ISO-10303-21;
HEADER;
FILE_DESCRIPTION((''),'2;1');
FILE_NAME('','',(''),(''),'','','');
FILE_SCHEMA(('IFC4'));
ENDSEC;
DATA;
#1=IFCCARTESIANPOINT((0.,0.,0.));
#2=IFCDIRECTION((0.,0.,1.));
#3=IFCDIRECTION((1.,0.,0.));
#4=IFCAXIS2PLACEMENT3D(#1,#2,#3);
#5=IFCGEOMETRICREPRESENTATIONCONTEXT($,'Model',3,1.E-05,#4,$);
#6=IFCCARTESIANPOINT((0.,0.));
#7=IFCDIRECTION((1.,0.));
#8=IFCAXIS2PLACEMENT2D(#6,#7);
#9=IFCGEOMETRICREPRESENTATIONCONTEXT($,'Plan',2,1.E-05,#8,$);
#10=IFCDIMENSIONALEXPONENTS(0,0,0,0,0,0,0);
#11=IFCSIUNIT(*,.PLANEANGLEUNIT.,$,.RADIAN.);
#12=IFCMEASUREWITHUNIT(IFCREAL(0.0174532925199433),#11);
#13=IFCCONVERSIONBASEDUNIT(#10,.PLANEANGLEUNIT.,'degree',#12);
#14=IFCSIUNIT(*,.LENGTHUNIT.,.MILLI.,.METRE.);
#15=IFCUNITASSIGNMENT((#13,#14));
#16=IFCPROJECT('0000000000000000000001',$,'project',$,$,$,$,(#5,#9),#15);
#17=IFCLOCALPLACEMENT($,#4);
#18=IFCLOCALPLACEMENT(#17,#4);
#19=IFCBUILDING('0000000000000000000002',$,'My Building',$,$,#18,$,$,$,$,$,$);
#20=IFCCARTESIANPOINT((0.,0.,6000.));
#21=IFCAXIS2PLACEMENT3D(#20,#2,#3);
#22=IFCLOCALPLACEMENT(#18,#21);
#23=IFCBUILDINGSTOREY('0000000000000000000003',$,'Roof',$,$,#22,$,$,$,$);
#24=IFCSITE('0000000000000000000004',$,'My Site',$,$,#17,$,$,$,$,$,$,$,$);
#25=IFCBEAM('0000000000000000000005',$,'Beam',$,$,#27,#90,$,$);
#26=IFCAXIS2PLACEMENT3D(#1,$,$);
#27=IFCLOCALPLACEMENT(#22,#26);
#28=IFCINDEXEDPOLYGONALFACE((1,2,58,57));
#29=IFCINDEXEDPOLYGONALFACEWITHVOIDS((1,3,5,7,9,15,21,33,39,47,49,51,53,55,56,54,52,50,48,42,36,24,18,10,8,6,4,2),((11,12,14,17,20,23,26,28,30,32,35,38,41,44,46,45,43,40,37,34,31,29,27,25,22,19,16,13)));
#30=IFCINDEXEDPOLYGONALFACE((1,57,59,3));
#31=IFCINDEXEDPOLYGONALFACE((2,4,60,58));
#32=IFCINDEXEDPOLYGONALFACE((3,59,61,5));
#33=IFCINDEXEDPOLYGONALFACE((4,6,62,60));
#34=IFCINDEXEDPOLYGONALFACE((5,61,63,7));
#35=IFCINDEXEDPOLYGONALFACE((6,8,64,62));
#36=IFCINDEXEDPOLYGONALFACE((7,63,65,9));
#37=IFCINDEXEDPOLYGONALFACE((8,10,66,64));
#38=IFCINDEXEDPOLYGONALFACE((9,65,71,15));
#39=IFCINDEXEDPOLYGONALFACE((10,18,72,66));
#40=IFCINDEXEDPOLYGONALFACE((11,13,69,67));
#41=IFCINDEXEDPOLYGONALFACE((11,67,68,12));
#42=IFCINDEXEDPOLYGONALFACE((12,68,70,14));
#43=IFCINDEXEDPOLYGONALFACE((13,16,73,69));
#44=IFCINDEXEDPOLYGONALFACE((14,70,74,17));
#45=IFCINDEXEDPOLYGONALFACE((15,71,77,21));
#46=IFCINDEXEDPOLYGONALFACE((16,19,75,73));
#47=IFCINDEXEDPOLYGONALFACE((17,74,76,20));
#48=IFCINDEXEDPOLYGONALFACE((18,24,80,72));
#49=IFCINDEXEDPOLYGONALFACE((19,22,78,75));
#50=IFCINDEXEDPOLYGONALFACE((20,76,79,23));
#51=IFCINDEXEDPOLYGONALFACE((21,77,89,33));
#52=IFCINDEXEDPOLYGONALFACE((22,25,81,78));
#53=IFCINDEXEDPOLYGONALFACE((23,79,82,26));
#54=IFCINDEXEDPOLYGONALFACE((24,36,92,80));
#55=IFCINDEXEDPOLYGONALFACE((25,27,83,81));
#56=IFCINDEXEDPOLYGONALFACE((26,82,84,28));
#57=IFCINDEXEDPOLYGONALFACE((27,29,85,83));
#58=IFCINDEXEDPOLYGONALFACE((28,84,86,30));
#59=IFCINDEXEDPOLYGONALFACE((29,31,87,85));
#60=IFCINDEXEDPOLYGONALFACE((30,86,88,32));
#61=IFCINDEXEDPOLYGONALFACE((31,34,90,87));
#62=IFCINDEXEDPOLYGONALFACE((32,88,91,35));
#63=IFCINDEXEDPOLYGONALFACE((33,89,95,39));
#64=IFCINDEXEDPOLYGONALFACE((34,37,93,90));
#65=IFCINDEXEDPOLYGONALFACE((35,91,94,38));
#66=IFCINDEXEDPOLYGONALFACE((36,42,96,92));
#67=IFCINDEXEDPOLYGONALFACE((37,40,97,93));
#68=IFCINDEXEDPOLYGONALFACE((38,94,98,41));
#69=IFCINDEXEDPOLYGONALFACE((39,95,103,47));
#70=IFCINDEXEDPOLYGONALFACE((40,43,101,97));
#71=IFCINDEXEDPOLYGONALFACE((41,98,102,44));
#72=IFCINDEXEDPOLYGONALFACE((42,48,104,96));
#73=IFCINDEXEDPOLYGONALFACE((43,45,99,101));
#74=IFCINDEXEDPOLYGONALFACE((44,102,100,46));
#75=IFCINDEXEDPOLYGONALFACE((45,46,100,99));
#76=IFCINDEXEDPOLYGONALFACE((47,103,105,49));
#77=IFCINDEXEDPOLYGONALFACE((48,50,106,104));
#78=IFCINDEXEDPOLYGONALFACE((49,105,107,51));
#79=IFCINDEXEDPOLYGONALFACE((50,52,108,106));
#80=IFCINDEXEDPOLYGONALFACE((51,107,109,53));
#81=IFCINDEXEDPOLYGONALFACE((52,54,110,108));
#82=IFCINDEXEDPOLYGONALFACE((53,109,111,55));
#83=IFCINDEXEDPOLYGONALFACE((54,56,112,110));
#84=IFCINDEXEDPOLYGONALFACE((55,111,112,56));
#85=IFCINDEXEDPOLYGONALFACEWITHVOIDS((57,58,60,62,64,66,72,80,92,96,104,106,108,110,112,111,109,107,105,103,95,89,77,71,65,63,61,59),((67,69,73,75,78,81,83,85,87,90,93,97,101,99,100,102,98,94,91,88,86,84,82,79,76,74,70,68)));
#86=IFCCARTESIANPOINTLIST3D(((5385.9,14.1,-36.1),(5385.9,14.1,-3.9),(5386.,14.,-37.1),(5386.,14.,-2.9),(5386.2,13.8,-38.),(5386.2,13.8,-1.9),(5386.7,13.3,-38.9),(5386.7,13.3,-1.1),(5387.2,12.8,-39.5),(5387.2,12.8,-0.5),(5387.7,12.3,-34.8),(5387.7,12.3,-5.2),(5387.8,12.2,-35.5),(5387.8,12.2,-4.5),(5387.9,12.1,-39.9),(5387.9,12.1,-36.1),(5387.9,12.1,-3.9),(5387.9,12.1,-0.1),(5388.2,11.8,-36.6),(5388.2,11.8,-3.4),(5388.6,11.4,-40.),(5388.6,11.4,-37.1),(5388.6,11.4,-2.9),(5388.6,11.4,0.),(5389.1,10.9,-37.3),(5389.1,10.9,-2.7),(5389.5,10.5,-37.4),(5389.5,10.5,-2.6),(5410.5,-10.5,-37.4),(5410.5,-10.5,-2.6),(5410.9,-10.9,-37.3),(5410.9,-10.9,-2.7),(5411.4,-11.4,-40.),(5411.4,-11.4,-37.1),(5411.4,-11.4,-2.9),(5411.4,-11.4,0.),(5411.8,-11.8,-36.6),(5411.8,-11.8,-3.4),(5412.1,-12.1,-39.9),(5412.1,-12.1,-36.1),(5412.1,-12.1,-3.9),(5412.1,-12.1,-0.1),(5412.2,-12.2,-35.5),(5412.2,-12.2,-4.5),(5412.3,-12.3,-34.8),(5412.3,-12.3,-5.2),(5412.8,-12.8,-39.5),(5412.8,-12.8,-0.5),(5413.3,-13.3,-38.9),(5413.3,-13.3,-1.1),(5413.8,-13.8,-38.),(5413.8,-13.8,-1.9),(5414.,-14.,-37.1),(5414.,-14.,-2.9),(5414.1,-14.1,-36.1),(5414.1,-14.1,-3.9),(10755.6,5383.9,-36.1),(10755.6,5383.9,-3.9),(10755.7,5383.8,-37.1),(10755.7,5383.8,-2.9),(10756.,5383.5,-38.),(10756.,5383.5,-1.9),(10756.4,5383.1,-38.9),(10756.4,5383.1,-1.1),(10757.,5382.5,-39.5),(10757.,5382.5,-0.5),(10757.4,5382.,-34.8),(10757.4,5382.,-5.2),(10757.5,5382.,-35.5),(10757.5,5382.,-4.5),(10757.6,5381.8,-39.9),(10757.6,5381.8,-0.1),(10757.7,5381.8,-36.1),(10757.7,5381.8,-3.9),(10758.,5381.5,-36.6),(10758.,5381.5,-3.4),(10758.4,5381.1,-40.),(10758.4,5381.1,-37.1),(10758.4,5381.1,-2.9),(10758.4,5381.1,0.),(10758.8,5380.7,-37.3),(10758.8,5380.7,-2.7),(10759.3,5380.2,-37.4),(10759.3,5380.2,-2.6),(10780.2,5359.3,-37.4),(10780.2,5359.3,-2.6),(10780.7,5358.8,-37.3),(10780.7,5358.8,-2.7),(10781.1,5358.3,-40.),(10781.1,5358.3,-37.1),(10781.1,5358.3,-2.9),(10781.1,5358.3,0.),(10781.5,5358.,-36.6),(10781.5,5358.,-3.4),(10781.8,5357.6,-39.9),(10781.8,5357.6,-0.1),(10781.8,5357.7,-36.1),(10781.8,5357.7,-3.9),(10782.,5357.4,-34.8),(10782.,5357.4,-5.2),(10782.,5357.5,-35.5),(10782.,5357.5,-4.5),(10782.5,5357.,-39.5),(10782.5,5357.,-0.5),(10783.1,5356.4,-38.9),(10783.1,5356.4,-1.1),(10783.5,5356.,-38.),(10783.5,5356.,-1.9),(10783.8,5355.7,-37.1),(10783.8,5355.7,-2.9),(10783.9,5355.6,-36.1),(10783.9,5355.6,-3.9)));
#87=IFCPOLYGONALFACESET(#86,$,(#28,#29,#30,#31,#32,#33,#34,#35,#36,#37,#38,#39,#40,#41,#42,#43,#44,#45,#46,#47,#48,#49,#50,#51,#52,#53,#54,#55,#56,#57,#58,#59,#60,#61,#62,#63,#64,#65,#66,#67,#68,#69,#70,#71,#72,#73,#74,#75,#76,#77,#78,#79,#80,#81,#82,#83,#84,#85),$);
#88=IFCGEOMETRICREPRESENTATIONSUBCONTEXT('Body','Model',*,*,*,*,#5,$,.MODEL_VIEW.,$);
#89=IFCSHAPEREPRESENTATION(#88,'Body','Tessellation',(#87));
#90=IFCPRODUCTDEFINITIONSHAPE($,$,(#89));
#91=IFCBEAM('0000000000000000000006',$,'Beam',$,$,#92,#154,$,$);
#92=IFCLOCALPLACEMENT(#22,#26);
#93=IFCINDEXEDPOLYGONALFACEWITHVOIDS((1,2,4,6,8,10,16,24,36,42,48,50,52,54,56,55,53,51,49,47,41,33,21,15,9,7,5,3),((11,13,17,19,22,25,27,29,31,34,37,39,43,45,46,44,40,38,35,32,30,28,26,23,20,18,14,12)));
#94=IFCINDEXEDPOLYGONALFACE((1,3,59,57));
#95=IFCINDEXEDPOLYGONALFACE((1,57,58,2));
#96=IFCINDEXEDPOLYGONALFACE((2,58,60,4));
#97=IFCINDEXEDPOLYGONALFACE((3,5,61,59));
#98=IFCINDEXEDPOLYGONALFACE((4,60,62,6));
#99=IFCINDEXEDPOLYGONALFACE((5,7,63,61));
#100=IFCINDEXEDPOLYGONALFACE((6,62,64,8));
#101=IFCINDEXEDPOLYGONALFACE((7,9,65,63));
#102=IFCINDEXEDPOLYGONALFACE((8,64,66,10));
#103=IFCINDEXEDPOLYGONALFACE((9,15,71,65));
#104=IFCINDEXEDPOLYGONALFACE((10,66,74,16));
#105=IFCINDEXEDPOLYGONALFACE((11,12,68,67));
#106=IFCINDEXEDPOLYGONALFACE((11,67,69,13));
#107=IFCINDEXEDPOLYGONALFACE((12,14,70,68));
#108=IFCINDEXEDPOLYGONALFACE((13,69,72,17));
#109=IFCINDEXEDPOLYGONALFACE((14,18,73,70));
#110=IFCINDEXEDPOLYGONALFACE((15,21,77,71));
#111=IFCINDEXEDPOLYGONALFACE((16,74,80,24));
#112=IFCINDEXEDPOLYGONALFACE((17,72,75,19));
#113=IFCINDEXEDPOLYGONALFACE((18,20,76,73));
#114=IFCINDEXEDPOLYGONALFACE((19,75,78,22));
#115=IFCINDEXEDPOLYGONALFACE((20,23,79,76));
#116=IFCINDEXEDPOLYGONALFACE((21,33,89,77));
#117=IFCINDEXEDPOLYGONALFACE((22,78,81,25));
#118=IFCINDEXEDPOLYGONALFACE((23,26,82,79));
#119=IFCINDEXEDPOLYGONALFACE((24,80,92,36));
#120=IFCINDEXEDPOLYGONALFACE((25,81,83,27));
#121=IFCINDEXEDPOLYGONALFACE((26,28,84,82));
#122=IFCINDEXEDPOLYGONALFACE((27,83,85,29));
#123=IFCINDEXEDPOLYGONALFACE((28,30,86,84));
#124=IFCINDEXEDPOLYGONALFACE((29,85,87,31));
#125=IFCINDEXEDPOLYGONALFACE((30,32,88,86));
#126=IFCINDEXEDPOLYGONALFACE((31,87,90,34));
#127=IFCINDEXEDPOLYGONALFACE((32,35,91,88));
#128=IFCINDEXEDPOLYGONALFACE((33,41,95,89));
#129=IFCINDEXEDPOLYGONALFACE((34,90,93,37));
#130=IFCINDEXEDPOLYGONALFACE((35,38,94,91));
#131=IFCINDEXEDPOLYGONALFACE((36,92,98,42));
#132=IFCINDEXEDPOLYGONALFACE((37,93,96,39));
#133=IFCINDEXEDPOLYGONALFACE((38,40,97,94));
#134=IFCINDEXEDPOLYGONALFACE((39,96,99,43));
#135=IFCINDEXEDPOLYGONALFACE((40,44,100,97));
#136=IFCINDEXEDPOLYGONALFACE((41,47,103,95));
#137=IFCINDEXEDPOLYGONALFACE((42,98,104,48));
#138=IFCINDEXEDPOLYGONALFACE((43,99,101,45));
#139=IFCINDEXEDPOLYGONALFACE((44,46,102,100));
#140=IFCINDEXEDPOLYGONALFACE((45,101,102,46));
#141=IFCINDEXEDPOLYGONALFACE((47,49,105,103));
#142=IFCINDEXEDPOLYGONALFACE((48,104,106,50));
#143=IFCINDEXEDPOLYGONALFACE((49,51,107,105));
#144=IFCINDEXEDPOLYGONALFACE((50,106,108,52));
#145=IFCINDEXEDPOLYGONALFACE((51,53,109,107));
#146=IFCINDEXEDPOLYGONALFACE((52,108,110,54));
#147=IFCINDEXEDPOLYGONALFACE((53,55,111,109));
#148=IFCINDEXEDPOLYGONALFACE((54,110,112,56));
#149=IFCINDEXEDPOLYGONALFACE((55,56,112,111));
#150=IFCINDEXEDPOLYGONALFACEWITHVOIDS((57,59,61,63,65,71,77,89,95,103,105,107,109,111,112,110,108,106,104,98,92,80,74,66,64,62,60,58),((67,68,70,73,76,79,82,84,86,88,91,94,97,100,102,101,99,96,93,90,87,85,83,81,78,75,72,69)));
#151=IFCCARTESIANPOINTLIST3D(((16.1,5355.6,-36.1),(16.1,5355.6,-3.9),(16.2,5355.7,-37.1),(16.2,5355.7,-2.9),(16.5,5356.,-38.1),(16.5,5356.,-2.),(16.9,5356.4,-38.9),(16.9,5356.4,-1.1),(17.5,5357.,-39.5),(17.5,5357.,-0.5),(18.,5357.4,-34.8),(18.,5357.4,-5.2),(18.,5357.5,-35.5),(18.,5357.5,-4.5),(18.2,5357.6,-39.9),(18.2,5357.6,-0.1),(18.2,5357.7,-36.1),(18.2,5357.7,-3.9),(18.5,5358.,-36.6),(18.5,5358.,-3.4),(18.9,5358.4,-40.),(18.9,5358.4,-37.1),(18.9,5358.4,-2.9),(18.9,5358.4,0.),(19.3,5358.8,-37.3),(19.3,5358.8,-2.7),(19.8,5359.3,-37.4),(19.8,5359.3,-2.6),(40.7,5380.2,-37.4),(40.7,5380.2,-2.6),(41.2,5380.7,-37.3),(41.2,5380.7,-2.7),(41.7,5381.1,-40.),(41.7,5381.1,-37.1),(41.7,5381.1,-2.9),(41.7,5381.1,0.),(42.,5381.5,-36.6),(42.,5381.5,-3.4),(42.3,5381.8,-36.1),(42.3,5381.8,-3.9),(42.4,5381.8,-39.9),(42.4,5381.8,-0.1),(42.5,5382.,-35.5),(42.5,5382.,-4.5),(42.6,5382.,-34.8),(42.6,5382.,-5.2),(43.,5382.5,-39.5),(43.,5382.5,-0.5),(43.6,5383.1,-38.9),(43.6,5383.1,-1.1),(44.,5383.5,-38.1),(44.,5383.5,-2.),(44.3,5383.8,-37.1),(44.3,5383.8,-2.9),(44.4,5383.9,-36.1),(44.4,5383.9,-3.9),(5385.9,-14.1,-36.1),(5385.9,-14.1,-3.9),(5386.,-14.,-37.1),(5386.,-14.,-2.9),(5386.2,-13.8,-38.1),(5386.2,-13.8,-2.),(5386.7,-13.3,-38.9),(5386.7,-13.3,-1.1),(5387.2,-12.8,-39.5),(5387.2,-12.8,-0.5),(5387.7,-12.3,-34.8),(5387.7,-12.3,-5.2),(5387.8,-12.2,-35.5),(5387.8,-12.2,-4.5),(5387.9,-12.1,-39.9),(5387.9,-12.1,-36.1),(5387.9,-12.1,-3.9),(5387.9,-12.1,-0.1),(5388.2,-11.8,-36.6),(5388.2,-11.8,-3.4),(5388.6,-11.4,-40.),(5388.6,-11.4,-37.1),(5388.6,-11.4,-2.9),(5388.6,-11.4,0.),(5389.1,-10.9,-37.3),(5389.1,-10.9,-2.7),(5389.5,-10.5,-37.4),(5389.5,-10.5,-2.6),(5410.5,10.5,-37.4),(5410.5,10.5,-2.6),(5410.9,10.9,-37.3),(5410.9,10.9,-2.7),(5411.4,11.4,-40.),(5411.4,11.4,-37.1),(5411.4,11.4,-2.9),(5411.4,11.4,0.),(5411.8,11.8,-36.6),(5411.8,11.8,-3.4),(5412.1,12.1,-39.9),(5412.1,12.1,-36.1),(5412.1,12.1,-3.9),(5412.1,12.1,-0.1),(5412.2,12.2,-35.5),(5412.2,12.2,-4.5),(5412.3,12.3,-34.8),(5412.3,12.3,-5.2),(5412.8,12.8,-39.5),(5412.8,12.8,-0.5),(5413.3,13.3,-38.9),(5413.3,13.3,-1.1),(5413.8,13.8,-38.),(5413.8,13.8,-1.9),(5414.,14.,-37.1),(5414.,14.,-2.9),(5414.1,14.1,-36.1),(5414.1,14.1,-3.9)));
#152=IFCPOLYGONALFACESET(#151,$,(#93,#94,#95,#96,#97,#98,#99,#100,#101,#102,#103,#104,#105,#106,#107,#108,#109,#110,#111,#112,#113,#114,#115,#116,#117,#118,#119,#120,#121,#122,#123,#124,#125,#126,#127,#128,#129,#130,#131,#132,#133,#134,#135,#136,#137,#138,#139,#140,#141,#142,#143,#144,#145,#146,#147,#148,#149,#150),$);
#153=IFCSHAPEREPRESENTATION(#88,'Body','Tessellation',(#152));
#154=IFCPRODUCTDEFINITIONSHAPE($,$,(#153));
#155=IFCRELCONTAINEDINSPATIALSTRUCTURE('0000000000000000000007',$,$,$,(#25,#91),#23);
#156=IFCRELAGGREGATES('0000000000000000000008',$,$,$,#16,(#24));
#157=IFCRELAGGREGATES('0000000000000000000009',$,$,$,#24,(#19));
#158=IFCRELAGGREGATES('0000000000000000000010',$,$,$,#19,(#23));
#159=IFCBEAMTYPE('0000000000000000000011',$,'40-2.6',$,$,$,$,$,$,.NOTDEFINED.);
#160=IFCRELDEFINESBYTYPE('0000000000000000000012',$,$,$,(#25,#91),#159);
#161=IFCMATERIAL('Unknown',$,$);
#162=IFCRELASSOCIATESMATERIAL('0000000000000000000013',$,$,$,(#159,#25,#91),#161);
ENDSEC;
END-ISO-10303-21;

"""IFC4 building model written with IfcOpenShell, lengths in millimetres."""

from ifc_helpers import new_model, entity, si_unit, converted_unit, frame, origin_with_axes, origin_2d_with_axis, place, context, subcontext, project, spatial, hollow_rectangle, extrude, material, material_profile, profile_set, profile_usage, type_object, element, save


model = new_model("IFC4")

# Units and contexts
model_context = context("Model", 3, precision=1e-05, world=origin_with_axes())
plan_context = context("Plan", 2, precision=1e-05, world=origin_2d_with_axis())
body_context = subcontext(model_context, "Body", "Model", "MODEL_VIEW")
ifc_project = project(units=[converted_unit("PLANEANGLEUNIT", "degree", entity("IfcReal", 0.0174532925199433), si_unit("PLANEANGLEUNIT", "RADIAN"), dimensions=[0, 0, 0, 0, 0, 0, 0]), si_unit("LENGTHUNIT", "METRE", prefix="MILLI")], contexts=[model_context, plan_context])

# Site, building, storey
site_placement = place(None, origin_with_axes())
site = spatial("IfcSite", under=ifc_project, at=site_placement, Name="My Site")
building_placement = place(site_placement, origin_with_axes())
building = spatial("IfcBuilding", under=site, at=building_placement, Name="My Building")
storey_placement = place(building_placement, frame((0.0, 0.0, 6000.0), z_axis=(0.0, 0.0, 1.0), x_axis=(1.0, 0.0, 0.0)))
storey = spatial("IfcBuildingStorey", under=building, at=storey_placement, Name="Roof")

# Beams
ifc_material = material(Name="Unknown")
ifc_material_profile_1 = material_profile(ifc_material, hollow_rectangle(XDim=40.0, YDim=40.0, WallThickness=2.6, InnerFilletRadius=2.6, OuterFilletRadius=3.9))
ifc_profile_set_1 = profile_set([ifc_material_profile_1])
beam_type_1 = type_object("IfcBeamType", Name="40-2.6", PredefinedType="NOTDEFINED", material=ifc_profile_set_1)
ifc_profile_usage_1 = profile_usage(ifc_profile_set_1, cardinal=8)
beam_1_placement = place(storey_placement, frame((5400.0, 0.0, 0.0), z_axis=(0.707107, 0.707107, 0.0), x_axis=(-0.707107, 0.707107, 0.0)))
element("IfcBeam", 1, at=beam_1_placement, inside=storey, type_object=beam_type_1, material=ifc_profile_usage_1, Name="Beam", context=body_context, shape_type="SweptSolid", body=[
    extrude(hollow_rectangle(XDim=40.0, YDim=40.0, WallThickness=2.6, InnerFilletRadius=2.6, OuterFilletRadius=3.9), frame((0.0, -20.0, 0.0), z_axis=(0.0, 0.0, 1.0), x_axis=(1.0, 0.0, 0.0)), (0.0, 0.0, 1.0), 7594.0),
])
ifc_profile_usage_2 = profile_usage(ifc_profile_set_1, cardinal=8)
beam_2_placement = place(storey_placement, frame((5400.0, 0.0, 0.0), z_axis=(-0.707107, 0.707107, 0.0), x_axis=(-0.707107, -0.707107, 0.0)))
element("IfcBeam", 2, at=beam_2_placement, inside=storey, type_object=beam_type_1, material=ifc_profile_usage_2, Name="Beam", context=body_context, shape_type="SweptSolid", body=[
    extrude(hollow_rectangle(XDim=40.0, YDim=40.0, WallThickness=2.6, InnerFilletRadius=2.6, OuterFilletRadius=3.9), frame((0.0, -20.0, 0.0), z_axis=(0.0, 0.0, 1.0), x_axis=(1.0, 0.0, 0.0)), (0.0, 0.0, 1.0), 7594.0),
])

save(model, "model.ifc")
